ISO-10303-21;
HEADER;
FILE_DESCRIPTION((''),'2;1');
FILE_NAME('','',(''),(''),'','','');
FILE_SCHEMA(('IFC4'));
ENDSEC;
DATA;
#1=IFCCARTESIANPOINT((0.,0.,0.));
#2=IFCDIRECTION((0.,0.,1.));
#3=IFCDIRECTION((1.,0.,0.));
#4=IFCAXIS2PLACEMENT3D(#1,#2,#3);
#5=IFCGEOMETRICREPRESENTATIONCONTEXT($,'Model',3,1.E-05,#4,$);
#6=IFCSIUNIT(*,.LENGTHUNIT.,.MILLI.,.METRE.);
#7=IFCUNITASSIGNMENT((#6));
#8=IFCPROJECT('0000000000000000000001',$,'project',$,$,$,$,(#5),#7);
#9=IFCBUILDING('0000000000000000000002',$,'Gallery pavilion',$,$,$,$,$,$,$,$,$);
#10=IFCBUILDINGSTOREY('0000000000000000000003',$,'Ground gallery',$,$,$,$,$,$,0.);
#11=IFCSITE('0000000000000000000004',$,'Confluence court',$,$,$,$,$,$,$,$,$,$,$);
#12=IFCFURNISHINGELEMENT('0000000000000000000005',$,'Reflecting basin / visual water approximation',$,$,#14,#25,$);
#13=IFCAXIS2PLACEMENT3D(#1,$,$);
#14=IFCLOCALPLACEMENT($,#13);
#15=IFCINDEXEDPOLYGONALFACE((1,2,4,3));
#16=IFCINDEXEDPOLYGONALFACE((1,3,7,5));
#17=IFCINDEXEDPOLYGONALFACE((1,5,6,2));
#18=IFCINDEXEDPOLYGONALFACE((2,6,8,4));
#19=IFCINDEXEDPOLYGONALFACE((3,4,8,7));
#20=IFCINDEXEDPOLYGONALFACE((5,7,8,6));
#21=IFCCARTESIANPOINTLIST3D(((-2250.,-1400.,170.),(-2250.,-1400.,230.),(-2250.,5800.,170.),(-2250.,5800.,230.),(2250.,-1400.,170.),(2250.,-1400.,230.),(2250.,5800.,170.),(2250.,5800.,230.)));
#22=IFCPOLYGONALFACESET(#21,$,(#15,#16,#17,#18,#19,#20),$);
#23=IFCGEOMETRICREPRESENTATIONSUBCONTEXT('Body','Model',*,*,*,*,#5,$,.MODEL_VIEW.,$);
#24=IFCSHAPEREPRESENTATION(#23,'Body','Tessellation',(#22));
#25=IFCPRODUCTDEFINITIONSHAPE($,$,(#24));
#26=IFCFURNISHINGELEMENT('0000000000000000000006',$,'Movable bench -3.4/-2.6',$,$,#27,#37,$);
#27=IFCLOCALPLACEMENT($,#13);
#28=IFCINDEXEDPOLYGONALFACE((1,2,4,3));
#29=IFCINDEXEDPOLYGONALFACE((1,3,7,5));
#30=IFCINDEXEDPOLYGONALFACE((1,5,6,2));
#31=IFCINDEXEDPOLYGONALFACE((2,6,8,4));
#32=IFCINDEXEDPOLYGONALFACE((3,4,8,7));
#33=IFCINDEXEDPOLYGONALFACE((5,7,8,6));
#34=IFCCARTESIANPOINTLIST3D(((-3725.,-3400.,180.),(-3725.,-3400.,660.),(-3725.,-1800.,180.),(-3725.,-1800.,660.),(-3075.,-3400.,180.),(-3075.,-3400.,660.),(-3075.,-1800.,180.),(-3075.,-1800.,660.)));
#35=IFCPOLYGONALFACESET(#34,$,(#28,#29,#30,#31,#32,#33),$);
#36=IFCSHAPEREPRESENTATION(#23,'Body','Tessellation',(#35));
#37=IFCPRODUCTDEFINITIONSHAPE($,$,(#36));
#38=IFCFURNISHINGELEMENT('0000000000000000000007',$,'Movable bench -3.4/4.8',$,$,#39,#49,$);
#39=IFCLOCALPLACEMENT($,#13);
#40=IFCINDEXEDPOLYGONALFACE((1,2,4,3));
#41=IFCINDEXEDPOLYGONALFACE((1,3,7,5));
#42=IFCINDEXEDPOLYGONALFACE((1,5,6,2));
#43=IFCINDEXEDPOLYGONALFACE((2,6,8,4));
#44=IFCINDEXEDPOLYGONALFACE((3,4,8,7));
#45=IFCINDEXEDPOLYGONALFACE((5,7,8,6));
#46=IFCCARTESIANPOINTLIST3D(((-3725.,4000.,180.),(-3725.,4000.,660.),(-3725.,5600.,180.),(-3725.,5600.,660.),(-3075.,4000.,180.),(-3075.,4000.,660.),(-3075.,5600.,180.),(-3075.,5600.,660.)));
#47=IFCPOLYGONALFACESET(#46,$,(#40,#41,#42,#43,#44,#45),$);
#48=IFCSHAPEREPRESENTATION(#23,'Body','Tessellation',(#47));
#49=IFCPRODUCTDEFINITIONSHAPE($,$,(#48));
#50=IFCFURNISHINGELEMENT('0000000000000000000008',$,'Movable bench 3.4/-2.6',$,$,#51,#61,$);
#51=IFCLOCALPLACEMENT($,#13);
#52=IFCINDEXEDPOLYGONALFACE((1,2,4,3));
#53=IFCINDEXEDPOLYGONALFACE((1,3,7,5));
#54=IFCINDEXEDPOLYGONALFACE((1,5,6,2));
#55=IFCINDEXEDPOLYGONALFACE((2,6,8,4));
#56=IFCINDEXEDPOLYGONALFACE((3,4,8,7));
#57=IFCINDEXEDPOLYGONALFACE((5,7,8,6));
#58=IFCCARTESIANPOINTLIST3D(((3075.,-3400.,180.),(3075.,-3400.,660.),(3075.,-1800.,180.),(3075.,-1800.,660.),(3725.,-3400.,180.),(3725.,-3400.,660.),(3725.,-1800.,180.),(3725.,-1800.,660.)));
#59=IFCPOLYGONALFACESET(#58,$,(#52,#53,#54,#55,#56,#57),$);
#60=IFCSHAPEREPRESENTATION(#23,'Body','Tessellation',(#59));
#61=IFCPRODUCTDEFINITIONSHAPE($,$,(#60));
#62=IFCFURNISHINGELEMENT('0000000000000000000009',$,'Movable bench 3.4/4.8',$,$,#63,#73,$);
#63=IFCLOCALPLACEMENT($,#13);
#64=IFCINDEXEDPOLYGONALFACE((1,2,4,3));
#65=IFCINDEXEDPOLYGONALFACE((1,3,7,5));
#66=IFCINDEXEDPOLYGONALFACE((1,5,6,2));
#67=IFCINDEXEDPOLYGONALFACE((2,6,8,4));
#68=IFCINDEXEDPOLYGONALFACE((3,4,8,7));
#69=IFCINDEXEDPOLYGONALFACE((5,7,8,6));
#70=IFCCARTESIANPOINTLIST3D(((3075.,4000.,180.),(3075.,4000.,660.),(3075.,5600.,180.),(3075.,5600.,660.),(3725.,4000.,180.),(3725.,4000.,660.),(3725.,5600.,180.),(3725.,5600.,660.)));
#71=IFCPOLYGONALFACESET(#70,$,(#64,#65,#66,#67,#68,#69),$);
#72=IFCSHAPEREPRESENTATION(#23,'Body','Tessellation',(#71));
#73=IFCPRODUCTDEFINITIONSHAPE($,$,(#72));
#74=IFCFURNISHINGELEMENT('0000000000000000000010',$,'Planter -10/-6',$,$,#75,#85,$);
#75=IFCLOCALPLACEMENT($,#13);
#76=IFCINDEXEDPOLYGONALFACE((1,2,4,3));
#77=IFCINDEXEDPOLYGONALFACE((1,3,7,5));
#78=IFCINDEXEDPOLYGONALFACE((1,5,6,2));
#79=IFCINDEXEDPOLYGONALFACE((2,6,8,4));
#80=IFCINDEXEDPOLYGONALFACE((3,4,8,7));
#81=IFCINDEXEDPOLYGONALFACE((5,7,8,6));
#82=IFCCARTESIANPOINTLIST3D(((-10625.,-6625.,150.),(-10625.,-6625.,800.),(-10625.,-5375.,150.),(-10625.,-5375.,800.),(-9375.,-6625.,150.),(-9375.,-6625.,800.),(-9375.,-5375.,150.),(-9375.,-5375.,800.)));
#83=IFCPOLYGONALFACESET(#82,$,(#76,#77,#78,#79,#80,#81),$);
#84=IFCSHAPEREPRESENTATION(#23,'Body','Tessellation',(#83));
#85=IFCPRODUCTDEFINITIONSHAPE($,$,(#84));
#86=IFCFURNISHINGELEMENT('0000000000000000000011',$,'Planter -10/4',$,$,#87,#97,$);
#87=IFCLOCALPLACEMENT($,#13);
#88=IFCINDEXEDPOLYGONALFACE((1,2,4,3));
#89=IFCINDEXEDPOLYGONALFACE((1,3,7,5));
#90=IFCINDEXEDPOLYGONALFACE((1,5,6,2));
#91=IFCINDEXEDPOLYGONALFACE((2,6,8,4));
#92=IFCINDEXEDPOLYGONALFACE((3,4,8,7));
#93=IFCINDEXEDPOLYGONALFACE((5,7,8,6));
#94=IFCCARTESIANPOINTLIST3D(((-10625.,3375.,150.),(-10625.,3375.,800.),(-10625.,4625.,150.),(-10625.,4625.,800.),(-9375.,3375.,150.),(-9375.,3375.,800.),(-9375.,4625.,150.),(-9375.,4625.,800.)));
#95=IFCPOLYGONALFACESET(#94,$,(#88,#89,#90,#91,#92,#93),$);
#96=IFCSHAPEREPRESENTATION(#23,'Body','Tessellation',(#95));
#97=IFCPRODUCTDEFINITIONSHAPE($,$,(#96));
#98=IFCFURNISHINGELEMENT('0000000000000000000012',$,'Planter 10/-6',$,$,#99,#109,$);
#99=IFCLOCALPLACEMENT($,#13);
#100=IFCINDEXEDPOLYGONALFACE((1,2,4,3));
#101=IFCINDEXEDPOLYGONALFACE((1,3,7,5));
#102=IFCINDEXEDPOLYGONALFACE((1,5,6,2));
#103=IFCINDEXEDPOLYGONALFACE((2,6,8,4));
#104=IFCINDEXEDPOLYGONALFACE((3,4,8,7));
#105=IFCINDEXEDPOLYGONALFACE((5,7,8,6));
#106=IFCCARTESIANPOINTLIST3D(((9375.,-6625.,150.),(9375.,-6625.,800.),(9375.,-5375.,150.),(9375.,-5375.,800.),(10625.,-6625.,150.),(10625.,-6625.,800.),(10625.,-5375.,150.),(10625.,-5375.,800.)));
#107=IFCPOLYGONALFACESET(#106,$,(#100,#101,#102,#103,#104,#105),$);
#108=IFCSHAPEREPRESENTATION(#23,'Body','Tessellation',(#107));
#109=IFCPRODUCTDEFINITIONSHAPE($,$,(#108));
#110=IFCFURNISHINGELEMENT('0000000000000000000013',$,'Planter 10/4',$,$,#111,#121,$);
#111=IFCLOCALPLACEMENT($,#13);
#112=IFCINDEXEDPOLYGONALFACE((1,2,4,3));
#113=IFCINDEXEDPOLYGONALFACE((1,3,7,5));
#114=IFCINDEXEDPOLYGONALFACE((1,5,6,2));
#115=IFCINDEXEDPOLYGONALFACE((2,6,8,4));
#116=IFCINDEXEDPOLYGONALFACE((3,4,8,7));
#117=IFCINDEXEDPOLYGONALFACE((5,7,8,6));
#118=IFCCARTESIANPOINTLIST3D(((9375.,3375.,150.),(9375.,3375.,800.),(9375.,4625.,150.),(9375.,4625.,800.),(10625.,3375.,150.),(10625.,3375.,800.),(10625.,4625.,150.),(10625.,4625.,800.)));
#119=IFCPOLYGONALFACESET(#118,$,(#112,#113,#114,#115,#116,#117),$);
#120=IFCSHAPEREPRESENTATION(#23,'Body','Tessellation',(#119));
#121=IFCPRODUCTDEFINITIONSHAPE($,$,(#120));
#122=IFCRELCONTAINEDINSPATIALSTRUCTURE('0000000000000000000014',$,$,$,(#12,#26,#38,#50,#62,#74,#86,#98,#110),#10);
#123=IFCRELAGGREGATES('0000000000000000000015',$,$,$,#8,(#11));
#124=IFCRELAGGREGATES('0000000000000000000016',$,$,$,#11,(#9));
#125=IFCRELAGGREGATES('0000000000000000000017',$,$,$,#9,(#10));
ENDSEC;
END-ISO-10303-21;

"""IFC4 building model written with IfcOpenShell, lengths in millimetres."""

from ifc_helpers import new_model, si_unit, frame, origin_with_axes, place, context, subcontext, project, spatial, rectangle, extrude, element, save


model = new_model("IFC4")

# Units and contexts
model_context = context("Model", 3, precision=1e-05, world=origin_with_axes())
body_context = subcontext(model_context, "Body", "Model", "MODEL_VIEW")
ifc_project = project(units=[si_unit("LENGTHUNIT", "METRE", prefix="MILLI")], contexts=[model_context])

# Site, building, storey
site = spatial("IfcSite", under=ifc_project, Name="Confluence court")
building = spatial("IfcBuilding", under=site, Name="Gallery pavilion")
storey = spatial("IfcBuildingStorey", under=building, Name="Ground gallery", Elevation=0.0)

# Furnishing elements
furnishing_placement = place(None, frame((0.0, 2200.0, 170.0), z_axis=(0.0, 0.0, 1.0), x_axis=(1.0, 0.0, 0.0)))
element("IfcFurnishingElement", 1, at=furnishing_placement, inside=storey, Name="Reflecting basin / visual water approximation", context=body_context, shape_type="SweptSolid", body=[
    extrude(rectangle(XDim=4500.0, YDim=7200.0), origin_with_axes(), (0.0, 0.0, 1.0), 60.0),
])
for number, where, z_axis, x_axis, name in (
    (2, (-3400.0, -2600.0, 180.0), (0.0, 0.0, 1.0), (0.0, 1.0, 0.0), "Movable bench -3.4/-2.6"),
    (3, (-3400.0, 4800.0, 180.0), (0.0, 0.0, 1.0), (0.0, 1.0, 0.0), "Movable bench -3.4/4.8"),
    (4, (3400.0, -2600.0, 180.0), (0.0, 0.0, 1.0), (0.0, 1.0, 0.0), "Movable bench 3.4/-2.6"),
    (5, (3400.0, 4800.0, 180.0), (0.0, 0.0, 1.0), (0.0, 1.0, 0.0), "Movable bench 3.4/4.8"),
):
    element("IfcFurnishingElement", number, at=place(None, frame(where, z_axis=z_axis, x_axis=x_axis)), inside=storey, Name=name, context=body_context, shape_type="SweptSolid", body=[
        extrude(rectangle(XDim=1600.0, YDim=650.0), origin_with_axes(), (0.0, 0.0, 1.0), 480.0),
    ])
for number, where, z_axis, x_axis, name in (
    (6, (-10000.0, -6000.0, 150.0), (0.0, 0.0, 1.0), (1.0, 0.0, 0.0), "Planter -10/-6"),
    (7, (-10000.0, 4000.0, 150.0), (0.0, 0.0, 1.0), (1.0, 0.0, 0.0), "Planter -10/4"),
    (8, (10000.0, -6000.0, 150.0), (0.0, 0.0, 1.0), (1.0, 0.0, 0.0), "Planter 10/-6"),
    (9, (10000.0, 4000.0, 150.0), (0.0, 0.0, 1.0), (1.0, 0.0, 0.0), "Planter 10/4"),
):
    element("IfcFurnishingElement", number, at=place(None, frame(where, z_axis=z_axis, x_axis=x_axis)), inside=storey, Name=name, context=body_context, shape_type="SweptSolid", body=[
        extrude(rectangle(XDim=1250.0, YDim=1250.0), origin_with_axes(), (0.0, 0.0, 1.0), 650.0),
    ])

save(model, "model.ifc")
